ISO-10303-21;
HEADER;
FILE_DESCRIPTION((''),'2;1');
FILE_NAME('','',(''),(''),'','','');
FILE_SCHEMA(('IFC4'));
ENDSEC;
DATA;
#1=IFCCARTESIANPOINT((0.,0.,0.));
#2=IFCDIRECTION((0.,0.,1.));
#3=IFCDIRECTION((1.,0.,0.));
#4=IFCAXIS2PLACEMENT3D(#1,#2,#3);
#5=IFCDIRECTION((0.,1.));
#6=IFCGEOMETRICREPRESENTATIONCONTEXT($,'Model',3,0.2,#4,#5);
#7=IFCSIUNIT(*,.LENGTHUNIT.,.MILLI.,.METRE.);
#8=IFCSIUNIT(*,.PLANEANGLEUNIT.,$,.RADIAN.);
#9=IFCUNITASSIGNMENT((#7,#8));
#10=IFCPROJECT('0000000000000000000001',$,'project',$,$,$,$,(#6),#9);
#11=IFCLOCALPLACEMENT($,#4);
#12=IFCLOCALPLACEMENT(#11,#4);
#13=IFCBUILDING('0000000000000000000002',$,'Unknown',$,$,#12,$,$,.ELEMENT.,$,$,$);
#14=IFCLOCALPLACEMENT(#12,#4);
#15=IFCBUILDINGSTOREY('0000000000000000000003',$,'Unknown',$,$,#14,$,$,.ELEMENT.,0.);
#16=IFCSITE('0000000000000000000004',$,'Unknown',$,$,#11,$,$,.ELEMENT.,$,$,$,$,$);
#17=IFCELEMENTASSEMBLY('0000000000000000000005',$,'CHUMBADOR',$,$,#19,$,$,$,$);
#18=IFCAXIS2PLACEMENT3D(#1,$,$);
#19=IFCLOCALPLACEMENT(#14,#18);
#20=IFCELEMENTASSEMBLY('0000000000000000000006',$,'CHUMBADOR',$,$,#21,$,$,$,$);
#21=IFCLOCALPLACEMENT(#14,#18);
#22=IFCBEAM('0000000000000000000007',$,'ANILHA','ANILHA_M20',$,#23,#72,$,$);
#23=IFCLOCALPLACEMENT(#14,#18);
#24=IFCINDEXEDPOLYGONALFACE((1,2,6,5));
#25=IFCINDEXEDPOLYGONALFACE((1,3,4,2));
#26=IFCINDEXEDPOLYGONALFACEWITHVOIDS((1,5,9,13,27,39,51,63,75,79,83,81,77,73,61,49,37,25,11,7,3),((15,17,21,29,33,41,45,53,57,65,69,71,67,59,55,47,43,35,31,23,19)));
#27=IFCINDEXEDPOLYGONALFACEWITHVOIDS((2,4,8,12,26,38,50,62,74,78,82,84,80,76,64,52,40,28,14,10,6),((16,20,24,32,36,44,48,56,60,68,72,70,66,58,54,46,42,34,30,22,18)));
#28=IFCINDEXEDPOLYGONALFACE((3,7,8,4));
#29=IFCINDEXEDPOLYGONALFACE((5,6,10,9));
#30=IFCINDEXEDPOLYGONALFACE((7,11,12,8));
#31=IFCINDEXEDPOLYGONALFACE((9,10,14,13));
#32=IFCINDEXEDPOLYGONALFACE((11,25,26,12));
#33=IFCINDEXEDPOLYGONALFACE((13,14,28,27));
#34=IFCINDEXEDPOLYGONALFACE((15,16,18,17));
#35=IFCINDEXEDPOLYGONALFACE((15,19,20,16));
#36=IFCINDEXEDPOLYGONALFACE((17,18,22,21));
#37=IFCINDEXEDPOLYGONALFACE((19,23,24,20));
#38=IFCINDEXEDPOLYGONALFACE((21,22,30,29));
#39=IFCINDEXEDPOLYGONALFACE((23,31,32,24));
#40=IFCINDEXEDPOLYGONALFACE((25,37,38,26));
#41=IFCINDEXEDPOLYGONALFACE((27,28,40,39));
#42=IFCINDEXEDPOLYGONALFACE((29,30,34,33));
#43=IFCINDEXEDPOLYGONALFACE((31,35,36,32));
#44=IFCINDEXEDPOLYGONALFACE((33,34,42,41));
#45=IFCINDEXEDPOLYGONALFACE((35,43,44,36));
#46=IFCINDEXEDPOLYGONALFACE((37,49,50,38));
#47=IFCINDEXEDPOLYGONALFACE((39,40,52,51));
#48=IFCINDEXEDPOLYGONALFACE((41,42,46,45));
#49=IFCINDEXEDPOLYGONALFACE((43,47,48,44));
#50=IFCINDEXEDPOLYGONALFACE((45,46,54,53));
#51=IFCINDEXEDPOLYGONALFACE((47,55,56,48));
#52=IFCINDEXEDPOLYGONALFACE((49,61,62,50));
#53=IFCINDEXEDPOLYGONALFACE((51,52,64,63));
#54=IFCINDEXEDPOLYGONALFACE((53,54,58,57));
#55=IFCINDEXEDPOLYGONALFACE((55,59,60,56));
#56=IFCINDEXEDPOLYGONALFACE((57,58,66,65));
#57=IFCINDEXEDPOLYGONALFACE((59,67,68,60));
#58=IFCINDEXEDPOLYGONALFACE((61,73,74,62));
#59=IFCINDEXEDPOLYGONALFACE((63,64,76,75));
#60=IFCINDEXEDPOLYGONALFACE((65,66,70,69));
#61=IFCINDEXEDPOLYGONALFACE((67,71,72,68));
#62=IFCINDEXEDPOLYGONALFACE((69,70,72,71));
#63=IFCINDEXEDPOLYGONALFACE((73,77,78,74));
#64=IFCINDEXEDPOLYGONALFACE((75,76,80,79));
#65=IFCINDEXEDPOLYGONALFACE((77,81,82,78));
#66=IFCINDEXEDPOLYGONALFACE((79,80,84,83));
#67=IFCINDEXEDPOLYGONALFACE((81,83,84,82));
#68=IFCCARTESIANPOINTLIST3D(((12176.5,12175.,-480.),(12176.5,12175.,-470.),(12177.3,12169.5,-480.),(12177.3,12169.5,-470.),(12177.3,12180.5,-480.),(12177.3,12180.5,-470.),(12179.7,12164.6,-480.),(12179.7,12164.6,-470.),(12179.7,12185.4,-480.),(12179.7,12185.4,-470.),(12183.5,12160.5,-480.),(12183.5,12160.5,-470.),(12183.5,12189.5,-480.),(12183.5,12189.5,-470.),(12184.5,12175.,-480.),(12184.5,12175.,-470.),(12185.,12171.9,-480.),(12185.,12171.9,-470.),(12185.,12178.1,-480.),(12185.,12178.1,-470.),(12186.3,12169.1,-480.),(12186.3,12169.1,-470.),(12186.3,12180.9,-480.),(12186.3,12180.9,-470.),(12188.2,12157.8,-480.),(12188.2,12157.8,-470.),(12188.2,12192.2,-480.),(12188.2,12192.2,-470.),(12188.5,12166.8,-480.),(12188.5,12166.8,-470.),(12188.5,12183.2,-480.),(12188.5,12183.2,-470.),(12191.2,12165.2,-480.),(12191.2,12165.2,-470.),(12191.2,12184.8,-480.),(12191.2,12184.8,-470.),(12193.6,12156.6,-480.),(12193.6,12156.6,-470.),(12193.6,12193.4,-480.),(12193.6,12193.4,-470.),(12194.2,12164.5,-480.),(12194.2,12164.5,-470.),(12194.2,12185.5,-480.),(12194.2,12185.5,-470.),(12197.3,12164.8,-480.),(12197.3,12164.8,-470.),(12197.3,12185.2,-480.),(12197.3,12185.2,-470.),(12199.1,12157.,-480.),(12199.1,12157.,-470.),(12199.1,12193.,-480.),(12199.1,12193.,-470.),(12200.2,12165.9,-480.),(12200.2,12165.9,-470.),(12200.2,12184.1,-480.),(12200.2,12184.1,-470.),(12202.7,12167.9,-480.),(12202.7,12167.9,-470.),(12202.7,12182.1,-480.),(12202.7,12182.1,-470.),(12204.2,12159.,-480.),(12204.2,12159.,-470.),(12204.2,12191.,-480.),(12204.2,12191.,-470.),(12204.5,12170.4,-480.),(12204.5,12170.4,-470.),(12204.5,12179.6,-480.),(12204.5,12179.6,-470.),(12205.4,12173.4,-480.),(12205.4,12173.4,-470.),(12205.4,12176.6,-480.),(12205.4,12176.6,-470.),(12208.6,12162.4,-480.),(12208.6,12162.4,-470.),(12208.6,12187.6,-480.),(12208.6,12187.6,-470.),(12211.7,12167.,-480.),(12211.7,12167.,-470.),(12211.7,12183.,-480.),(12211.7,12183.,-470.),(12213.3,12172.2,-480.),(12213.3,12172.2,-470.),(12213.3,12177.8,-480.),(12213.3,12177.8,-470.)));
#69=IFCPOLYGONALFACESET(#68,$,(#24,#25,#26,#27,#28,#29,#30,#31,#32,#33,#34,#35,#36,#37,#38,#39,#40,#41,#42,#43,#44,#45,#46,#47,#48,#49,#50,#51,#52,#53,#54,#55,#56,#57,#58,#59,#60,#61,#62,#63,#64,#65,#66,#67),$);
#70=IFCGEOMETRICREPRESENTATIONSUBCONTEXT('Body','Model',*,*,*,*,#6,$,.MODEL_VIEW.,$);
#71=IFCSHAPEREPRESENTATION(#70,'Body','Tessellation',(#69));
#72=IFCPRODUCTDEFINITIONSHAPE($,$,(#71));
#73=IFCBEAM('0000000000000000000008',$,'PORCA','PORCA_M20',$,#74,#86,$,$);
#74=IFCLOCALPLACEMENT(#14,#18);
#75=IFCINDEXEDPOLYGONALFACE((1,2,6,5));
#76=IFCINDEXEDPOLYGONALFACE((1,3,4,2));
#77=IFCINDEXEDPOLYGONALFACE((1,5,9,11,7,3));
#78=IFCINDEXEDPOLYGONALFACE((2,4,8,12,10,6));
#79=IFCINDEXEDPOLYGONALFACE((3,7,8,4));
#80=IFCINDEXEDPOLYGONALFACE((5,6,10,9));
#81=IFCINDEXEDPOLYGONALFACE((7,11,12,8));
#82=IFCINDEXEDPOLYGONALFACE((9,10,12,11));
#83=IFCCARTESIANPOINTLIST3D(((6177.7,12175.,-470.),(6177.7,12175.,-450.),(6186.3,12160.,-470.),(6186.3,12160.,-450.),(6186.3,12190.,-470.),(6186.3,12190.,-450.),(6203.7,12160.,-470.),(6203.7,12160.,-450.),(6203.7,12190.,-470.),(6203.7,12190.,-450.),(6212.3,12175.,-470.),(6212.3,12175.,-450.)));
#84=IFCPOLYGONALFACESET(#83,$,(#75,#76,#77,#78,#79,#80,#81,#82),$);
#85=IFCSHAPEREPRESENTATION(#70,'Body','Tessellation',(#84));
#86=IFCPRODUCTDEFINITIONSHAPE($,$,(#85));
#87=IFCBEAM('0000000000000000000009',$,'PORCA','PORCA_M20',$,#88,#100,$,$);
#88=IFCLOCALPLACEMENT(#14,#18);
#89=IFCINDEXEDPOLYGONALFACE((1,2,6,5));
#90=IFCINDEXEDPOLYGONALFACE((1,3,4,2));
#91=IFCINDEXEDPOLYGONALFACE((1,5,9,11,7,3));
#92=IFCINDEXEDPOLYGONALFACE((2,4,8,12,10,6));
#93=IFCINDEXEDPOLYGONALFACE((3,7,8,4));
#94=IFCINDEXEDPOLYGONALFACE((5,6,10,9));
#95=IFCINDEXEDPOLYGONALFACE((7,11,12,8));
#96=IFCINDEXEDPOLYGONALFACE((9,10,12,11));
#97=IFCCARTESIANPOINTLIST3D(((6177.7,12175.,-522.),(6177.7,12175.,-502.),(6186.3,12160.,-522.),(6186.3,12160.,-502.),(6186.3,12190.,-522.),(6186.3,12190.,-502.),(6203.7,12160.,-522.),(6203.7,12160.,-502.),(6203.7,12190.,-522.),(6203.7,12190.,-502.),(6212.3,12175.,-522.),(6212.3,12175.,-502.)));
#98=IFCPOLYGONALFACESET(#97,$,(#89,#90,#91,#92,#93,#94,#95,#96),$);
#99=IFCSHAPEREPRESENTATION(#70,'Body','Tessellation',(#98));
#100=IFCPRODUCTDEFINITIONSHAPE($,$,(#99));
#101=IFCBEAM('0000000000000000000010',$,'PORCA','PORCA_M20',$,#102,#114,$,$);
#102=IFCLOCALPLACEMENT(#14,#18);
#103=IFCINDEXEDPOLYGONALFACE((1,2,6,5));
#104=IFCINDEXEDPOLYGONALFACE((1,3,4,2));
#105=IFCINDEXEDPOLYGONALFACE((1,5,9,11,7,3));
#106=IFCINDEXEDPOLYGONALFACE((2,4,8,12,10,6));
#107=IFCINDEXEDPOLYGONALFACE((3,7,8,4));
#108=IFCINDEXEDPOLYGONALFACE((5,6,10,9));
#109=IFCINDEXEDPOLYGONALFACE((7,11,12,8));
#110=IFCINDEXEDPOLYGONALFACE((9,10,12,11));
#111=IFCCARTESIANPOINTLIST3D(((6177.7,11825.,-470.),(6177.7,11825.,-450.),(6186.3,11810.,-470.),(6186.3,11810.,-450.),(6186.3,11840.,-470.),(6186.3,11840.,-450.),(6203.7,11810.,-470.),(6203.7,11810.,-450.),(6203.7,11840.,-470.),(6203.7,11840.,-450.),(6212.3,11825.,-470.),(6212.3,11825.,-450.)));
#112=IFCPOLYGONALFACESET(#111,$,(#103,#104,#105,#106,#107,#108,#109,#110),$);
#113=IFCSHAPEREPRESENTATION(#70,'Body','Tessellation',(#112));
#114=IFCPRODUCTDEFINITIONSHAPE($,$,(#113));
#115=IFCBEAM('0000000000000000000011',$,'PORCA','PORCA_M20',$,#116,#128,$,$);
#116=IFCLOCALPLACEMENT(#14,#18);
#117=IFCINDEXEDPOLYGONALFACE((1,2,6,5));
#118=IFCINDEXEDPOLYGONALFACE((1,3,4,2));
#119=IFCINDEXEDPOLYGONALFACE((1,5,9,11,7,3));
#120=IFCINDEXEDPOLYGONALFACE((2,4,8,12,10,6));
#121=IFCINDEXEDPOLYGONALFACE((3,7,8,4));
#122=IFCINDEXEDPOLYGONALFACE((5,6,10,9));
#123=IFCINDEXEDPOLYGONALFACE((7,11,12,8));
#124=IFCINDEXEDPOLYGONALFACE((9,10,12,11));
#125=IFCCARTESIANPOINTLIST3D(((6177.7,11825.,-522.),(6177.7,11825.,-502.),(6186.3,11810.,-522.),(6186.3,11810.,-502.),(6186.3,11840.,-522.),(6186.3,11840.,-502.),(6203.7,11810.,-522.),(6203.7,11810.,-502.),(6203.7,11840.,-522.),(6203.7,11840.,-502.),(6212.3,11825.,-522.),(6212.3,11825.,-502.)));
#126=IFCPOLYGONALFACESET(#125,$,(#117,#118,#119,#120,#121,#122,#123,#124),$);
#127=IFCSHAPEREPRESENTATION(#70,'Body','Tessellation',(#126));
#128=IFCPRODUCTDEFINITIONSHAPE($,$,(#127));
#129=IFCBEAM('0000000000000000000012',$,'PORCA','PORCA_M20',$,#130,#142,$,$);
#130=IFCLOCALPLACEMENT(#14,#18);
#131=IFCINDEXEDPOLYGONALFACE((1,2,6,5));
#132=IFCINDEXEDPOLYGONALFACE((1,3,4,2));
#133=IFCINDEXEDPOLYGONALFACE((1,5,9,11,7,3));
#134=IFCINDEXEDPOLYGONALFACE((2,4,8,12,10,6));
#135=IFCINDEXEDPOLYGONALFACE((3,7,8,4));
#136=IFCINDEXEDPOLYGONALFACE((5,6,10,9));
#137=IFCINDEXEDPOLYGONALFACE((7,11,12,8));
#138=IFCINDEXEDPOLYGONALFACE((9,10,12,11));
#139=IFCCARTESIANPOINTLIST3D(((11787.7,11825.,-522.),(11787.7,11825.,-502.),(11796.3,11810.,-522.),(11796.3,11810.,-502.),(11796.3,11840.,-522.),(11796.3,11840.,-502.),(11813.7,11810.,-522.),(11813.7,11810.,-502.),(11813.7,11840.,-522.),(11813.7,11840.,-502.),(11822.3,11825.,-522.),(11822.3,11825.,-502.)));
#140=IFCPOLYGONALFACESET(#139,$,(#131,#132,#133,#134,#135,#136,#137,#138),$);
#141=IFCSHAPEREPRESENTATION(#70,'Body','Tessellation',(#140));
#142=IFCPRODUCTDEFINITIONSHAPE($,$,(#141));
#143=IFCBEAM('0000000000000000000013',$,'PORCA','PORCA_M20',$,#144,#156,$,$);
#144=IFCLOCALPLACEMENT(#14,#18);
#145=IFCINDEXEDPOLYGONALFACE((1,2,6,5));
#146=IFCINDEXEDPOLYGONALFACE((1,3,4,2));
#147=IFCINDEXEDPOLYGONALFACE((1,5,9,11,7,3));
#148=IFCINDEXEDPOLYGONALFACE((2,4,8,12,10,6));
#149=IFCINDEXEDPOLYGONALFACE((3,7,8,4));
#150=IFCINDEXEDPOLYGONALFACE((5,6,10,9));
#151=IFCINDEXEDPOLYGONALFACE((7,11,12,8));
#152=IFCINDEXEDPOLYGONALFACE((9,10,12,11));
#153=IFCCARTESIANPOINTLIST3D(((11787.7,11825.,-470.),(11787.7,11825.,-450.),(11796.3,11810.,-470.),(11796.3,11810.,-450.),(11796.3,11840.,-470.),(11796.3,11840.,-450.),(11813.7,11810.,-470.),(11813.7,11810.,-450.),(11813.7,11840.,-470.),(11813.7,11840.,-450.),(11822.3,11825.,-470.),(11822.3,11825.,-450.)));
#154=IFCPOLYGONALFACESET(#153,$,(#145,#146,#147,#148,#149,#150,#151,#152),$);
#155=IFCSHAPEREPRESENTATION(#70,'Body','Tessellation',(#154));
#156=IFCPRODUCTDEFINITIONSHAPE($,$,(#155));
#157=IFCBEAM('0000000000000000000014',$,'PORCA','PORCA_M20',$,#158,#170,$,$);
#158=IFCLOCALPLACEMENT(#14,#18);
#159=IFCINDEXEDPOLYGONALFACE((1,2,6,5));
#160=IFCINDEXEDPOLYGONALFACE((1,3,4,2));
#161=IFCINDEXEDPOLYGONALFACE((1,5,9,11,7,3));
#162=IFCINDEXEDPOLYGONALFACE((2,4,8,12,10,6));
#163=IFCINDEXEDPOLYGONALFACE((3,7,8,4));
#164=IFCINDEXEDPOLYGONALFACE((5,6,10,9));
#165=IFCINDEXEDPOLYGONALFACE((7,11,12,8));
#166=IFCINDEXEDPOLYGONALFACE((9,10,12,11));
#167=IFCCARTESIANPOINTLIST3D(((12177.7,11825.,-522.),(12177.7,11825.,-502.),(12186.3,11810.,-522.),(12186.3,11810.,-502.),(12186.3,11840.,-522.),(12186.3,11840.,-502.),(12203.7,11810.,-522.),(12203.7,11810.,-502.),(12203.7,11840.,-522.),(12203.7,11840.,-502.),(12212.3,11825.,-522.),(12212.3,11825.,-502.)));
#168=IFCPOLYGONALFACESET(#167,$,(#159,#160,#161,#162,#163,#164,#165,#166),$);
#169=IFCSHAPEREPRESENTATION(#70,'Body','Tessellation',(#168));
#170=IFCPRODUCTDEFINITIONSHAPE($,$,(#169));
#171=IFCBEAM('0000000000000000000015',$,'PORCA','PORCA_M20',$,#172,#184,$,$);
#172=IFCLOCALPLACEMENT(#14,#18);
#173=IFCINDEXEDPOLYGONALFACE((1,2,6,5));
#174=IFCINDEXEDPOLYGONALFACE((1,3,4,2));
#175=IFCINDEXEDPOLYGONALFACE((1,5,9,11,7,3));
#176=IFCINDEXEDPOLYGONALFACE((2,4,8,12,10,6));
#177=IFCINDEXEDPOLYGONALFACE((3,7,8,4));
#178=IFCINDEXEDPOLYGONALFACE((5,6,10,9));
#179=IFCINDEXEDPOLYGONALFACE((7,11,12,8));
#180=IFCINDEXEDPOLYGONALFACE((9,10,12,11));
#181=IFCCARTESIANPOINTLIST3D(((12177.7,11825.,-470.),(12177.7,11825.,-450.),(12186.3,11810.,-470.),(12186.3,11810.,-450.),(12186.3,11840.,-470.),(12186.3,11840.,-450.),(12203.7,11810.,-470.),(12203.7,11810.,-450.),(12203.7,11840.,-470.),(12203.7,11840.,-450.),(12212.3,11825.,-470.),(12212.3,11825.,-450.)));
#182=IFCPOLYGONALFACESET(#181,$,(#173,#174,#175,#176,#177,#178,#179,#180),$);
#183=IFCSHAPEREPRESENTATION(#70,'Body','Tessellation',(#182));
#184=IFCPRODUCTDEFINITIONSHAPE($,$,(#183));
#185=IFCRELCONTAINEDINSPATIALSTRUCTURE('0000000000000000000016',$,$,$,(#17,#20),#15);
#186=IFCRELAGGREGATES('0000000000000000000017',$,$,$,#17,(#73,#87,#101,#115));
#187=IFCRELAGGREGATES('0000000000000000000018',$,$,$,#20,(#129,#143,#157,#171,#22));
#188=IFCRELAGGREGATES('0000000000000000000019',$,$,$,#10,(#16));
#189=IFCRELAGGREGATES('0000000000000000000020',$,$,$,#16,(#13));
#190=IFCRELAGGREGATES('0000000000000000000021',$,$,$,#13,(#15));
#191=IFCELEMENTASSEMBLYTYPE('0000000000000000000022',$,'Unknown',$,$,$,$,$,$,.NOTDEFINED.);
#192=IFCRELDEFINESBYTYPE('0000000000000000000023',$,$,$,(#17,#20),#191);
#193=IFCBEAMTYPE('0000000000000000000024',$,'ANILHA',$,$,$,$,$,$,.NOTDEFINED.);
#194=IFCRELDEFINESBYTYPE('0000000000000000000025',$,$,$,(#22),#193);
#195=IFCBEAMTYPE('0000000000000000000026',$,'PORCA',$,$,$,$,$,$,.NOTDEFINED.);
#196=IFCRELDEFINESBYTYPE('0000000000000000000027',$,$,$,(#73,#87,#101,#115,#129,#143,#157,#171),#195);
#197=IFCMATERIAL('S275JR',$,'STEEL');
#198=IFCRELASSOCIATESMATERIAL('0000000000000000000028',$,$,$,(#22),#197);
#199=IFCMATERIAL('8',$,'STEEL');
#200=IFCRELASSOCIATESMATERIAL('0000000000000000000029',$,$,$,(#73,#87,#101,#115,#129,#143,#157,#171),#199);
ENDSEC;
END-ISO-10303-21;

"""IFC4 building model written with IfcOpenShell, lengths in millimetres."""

from ifc_helpers import new_model, si_unit, direction, frame, origin_with_axes, origin_2d_with_axis, place, context, subcontext, project, spatial, polyline, hollow_circle, outline, extrude, material, material_profile, profile_set, profile_usage, type_object, element, aggregate, save


model = new_model("IFC4")

# Units and contexts
model_context = context("Model", 3, precision=0.2, world=origin_with_axes(), true_north=direction((0.0, 1.0)))
body_context = subcontext(model_context, "Body", "Model", "MODEL_VIEW")
ifc_project = project(units=[si_unit("LENGTHUNIT", "METRE", prefix="MILLI"), si_unit("PLANEANGLEUNIT", "RADIAN")], contexts=[model_context])

# Site, building, storey
site_placement = place(None, origin_with_axes())
site = spatial("IfcSite", under=ifc_project, at=site_placement, Name="Unknown", CompositionType="ELEMENT")
building_placement = place(site_placement, origin_with_axes())
building = spatial("IfcBuilding", under=site, at=building_placement, Name="Unknown", CompositionType="ELEMENT")
storey_placement = place(building_placement, origin_with_axes())
storey = spatial("IfcBuildingStorey", under=building, at=storey_placement, Name="Unknown", CompositionType="ELEMENT", Elevation=0.0)

# Shared definitions
element_assembly_type = type_object("IfcElementAssemblyType", Name="Unknown", PredefinedType="NOTDEFINED")

# Element assemblies, beam
assembly_1_placement = place(storey_placement, frame((6195.0, 12175.0, -555.0), z_axis=(-1.0, 0.0, 0.0), x_axis=(0.0, 0.0, -1.0)))
assembly_1 = element("IfcElementAssembly", 1, at=assembly_1_placement, inside=storey, type_object=element_assembly_type, Name="CHUMBADOR")
ifc_material_1 = material(Name="S275JR", Category="STEEL")
ifc_material_profile_1 = material_profile(ifc_material_1, hollow_circle(Radius=18.5, WallThickness=8.0, at=origin_2d_with_axis()), Name="ANILHA_M20")
ifc_profile_set_1 = profile_set([ifc_material_profile_1])
ifc_profile_usage_1 = profile_usage(ifc_profile_set_1, cardinal=5)
beam_type_1 = type_object("IfcBeamType", Name="ANILHA", PredefinedType="NOTDEFINED")
assembly_2_placement = place(storey_placement, frame((12195.0, 12175.0, -555.0), z_axis=(-1.0, 0.0, 0.0), x_axis=(0.0, 0.0, -1.0)))
assembly_2 = element("IfcElementAssembly", 2, at=assembly_2_placement, inside=storey, type_object=element_assembly_type, Name="CHUMBADOR")
beam_1_placement = place(assembly_2_placement, frame((-85.0, 0.0, 0.0), z_axis=(0.0, 0.0, 1.0), x_axis=(1.0, 0.0, 0.0)))
beam_1 = element("IfcBeam", 3, at=beam_1_placement, type_object=beam_type_1, material=ifc_profile_usage_1, Name="ANILHA", Description="ANILHA_M20", context=body_context, shape_type="SolidModel", body=[
    extrude(hollow_circle(Radius=18.5, WallThickness=8.0, at=origin_2d_with_axis()), frame((0.0, 0.0, 0.0), z_axis=(-1.0, 0.0, 0.0), x_axis=(0.0, 0.0, 1.0)), (0.0, 0.0, -1.0), 10.0),
])

# Beams
ifc_material_2 = material(Name="8", Category="STEEL")
ifc_material_profile_2 = material_profile(ifc_material_2, outline(polyline([(8.7, -15.0), (17.3, 0.0), (8.7, 15.0), (-8.7, 15.0), (-17.3, 0.0), (-8.7, -15.0), (8.7, -15.0)])), Name="PORCA_M20")
ifc_profile_set_2 = profile_set([ifc_material_profile_2])
ifc_profile_usage_2 = profile_usage(ifc_profile_set_2, cardinal=5)
beam_type_2 = type_object("IfcBeamType", Name="PORCA", PredefinedType="NOTDEFINED")
beam_2_placement = place(assembly_1_placement, frame((-105.0, 0.0, 0.0), z_axis=(0.0, 0.0, -1.0), x_axis=(1.0, 0.0, 0.0)))
beam_2 = element("IfcBeam", 4, at=beam_2_placement, type_object=beam_type_2, material=ifc_profile_usage_2, Name="PORCA", Description="PORCA_M20", context=body_context, shape_type="SolidModel", body=[
    extrude(outline(polyline([(8.7, -15.0), (17.3, 0.0), (8.7, 15.0), (-8.7, 15.0), (-17.3, 0.0), (-8.7, -15.0), (8.7, -15.0)])), frame((0.0, 0.0, 0.0), z_axis=(-1.0, 0.0, 0.0), x_axis=(0.0, 0.0, 1.0)), (0.0, 0.0, -1.0), 20.0),
])
beam_3_placement = place(assembly_1_placement, frame((-53.0, 0.0, 0.0), z_axis=(0.0, 0.0, -1.0), x_axis=(1.0, 0.0, 0.0)))
beam_3 = element("IfcBeam", 5, at=beam_3_placement, type_object=beam_type_2, material=ifc_profile_usage_2, Name="PORCA", Description="PORCA_M20", context=body_context, shape_type="SolidModel", body=[
    extrude(outline(polyline([(8.7, -15.0), (17.3, 0.0), (8.7, 15.0), (-8.7, 15.0), (-17.3, 0.0), (-8.7, -15.0), (8.7, -15.0)])), frame((0.0, 0.0, 0.0), z_axis=(-1.0, 0.0, 0.0), x_axis=(0.0, 0.0, 1.0)), (0.0, 0.0, -1.0), 20.0),
])
beam_4_placement = place(assembly_1_placement, frame((-105.0, 350.0, 0.0), z_axis=(0.0, 0.0, -1.0), x_axis=(1.0, 0.0, 0.0)))
beam_4 = element("IfcBeam", 6, at=beam_4_placement, type_object=beam_type_2, material=ifc_profile_usage_2, Name="PORCA", Description="PORCA_M20", context=body_context, shape_type="SolidModel", body=[
    extrude(outline(polyline([(8.7, -15.0), (17.3, 0.0), (8.7, 15.0), (-8.7, 15.0), (-17.3, 0.0), (-8.7, -15.0), (8.7, -15.0)])), frame((0.0, 0.0, 0.0), z_axis=(-1.0, 0.0, 0.0), x_axis=(0.0, 0.0, 1.0)), (0.0, 0.0, -1.0), 20.0),
])
beam_5_placement = place(assembly_1_placement, frame((-53.0, 350.0, 0.0), z_axis=(0.0, 0.0, -1.0), x_axis=(1.0, 0.0, 0.0)))
beam_5 = element("IfcBeam", 7, at=beam_5_placement, type_object=beam_type_2, material=ifc_profile_usage_2, Name="PORCA", Description="PORCA_M20", context=body_context, shape_type="SolidModel", body=[
    extrude(outline(polyline([(8.7, -15.0), (17.3, 0.0), (8.7, 15.0), (-8.7, 15.0), (-17.3, 0.0), (-8.7, -15.0), (8.7, -15.0)])), frame((0.0, 0.0, 0.0), z_axis=(-1.0, 0.0, 0.0), x_axis=(0.0, 0.0, 1.0)), (0.0, 0.0, -1.0), 20.0),
])
aggregate(assembly_1, [beam_2, beam_3, beam_4, beam_5])
beam_6_placement = place(assembly_2_placement, frame((-53.0, 350.0, 390.0), z_axis=(0.0, 0.0, 1.0), x_axis=(1.0, 0.0, 0.0)))
beam_6 = element("IfcBeam", 8, at=beam_6_placement, type_object=beam_type_2, material=ifc_profile_usage_2, Name="PORCA", Description="PORCA_M20", context=body_context, shape_type="SolidModel", body=[
    extrude(outline(polyline([(8.7, -15.0), (17.3, 0.0), (8.7, 15.0), (-8.7, 15.0), (-17.3, 0.0), (-8.7, -15.0), (8.7, -15.0)])), frame((0.0, 0.0, 0.0), z_axis=(-1.0, 0.0, 0.0), x_axis=(0.0, 0.0, 1.0)), (0.0, 0.0, -1.0), 20.0),
])
beam_7_placement = place(assembly_2_placement, frame((-105.0, 350.0, 390.0), z_axis=(0.0, 0.0, 1.0), x_axis=(1.0, 0.0, 0.0)))
beam_7 = element("IfcBeam", 9, at=beam_7_placement, type_object=beam_type_2, material=ifc_profile_usage_2, Name="PORCA", Description="PORCA_M20", context=body_context, shape_type="SolidModel", body=[
    extrude(outline(polyline([(8.7, -15.0), (17.3, 0.0), (8.7, 15.0), (-8.7, 15.0), (-17.3, 0.0), (-8.7, -15.0), (8.7, -15.0)])), frame((0.0, 0.0, 0.0), z_axis=(-1.0, 0.0, 0.0), x_axis=(0.0, 0.0, 1.0)), (0.0, 0.0, -1.0), 20.0),
])
beam_8_placement = place(assembly_2_placement, frame((-53.0, 350.0, 0.0), z_axis=(0.0, 0.0, -1.0), x_axis=(1.0, 0.0, 0.0)))
beam_8 = element("IfcBeam", 10, at=beam_8_placement, type_object=beam_type_2, material=ifc_profile_usage_2, Name="PORCA", Description="PORCA_M20", context=body_context, shape_type="SolidModel", body=[
    extrude(outline(polyline([(8.7, -15.0), (17.3, 0.0), (8.7, 15.0), (-8.7, 15.0), (-17.3, 0.0), (-8.7, -15.0), (8.7, -15.0)])), frame((0.0, 0.0, 0.0), z_axis=(-1.0, 0.0, 0.0), x_axis=(0.0, 0.0, 1.0)), (0.0, 0.0, -1.0), 20.0),
])
beam_9_placement = place(assembly_2_placement, frame((-105.0, 350.0, 0.0), z_axis=(0.0, 0.0, -1.0), x_axis=(1.0, 0.0, 0.0)))
beam_9 = element("IfcBeam", 11, at=beam_9_placement, type_object=beam_type_2, material=ifc_profile_usage_2, Name="PORCA", Description="PORCA_M20", context=body_context, shape_type="SolidModel", body=[
    extrude(outline(polyline([(8.7, -15.0), (17.3, 0.0), (8.7, 15.0), (-8.7, 15.0), (-17.3, 0.0), (-8.7, -15.0), (8.7, -15.0)])), frame((0.0, 0.0, 0.0), z_axis=(-1.0, 0.0, 0.0), x_axis=(0.0, 0.0, 1.0)), (0.0, 0.0, -1.0), 20.0),
])
aggregate(assembly_2, [beam_6, beam_7, beam_8, beam_9, beam_1])

save(model, "model.ifc")
